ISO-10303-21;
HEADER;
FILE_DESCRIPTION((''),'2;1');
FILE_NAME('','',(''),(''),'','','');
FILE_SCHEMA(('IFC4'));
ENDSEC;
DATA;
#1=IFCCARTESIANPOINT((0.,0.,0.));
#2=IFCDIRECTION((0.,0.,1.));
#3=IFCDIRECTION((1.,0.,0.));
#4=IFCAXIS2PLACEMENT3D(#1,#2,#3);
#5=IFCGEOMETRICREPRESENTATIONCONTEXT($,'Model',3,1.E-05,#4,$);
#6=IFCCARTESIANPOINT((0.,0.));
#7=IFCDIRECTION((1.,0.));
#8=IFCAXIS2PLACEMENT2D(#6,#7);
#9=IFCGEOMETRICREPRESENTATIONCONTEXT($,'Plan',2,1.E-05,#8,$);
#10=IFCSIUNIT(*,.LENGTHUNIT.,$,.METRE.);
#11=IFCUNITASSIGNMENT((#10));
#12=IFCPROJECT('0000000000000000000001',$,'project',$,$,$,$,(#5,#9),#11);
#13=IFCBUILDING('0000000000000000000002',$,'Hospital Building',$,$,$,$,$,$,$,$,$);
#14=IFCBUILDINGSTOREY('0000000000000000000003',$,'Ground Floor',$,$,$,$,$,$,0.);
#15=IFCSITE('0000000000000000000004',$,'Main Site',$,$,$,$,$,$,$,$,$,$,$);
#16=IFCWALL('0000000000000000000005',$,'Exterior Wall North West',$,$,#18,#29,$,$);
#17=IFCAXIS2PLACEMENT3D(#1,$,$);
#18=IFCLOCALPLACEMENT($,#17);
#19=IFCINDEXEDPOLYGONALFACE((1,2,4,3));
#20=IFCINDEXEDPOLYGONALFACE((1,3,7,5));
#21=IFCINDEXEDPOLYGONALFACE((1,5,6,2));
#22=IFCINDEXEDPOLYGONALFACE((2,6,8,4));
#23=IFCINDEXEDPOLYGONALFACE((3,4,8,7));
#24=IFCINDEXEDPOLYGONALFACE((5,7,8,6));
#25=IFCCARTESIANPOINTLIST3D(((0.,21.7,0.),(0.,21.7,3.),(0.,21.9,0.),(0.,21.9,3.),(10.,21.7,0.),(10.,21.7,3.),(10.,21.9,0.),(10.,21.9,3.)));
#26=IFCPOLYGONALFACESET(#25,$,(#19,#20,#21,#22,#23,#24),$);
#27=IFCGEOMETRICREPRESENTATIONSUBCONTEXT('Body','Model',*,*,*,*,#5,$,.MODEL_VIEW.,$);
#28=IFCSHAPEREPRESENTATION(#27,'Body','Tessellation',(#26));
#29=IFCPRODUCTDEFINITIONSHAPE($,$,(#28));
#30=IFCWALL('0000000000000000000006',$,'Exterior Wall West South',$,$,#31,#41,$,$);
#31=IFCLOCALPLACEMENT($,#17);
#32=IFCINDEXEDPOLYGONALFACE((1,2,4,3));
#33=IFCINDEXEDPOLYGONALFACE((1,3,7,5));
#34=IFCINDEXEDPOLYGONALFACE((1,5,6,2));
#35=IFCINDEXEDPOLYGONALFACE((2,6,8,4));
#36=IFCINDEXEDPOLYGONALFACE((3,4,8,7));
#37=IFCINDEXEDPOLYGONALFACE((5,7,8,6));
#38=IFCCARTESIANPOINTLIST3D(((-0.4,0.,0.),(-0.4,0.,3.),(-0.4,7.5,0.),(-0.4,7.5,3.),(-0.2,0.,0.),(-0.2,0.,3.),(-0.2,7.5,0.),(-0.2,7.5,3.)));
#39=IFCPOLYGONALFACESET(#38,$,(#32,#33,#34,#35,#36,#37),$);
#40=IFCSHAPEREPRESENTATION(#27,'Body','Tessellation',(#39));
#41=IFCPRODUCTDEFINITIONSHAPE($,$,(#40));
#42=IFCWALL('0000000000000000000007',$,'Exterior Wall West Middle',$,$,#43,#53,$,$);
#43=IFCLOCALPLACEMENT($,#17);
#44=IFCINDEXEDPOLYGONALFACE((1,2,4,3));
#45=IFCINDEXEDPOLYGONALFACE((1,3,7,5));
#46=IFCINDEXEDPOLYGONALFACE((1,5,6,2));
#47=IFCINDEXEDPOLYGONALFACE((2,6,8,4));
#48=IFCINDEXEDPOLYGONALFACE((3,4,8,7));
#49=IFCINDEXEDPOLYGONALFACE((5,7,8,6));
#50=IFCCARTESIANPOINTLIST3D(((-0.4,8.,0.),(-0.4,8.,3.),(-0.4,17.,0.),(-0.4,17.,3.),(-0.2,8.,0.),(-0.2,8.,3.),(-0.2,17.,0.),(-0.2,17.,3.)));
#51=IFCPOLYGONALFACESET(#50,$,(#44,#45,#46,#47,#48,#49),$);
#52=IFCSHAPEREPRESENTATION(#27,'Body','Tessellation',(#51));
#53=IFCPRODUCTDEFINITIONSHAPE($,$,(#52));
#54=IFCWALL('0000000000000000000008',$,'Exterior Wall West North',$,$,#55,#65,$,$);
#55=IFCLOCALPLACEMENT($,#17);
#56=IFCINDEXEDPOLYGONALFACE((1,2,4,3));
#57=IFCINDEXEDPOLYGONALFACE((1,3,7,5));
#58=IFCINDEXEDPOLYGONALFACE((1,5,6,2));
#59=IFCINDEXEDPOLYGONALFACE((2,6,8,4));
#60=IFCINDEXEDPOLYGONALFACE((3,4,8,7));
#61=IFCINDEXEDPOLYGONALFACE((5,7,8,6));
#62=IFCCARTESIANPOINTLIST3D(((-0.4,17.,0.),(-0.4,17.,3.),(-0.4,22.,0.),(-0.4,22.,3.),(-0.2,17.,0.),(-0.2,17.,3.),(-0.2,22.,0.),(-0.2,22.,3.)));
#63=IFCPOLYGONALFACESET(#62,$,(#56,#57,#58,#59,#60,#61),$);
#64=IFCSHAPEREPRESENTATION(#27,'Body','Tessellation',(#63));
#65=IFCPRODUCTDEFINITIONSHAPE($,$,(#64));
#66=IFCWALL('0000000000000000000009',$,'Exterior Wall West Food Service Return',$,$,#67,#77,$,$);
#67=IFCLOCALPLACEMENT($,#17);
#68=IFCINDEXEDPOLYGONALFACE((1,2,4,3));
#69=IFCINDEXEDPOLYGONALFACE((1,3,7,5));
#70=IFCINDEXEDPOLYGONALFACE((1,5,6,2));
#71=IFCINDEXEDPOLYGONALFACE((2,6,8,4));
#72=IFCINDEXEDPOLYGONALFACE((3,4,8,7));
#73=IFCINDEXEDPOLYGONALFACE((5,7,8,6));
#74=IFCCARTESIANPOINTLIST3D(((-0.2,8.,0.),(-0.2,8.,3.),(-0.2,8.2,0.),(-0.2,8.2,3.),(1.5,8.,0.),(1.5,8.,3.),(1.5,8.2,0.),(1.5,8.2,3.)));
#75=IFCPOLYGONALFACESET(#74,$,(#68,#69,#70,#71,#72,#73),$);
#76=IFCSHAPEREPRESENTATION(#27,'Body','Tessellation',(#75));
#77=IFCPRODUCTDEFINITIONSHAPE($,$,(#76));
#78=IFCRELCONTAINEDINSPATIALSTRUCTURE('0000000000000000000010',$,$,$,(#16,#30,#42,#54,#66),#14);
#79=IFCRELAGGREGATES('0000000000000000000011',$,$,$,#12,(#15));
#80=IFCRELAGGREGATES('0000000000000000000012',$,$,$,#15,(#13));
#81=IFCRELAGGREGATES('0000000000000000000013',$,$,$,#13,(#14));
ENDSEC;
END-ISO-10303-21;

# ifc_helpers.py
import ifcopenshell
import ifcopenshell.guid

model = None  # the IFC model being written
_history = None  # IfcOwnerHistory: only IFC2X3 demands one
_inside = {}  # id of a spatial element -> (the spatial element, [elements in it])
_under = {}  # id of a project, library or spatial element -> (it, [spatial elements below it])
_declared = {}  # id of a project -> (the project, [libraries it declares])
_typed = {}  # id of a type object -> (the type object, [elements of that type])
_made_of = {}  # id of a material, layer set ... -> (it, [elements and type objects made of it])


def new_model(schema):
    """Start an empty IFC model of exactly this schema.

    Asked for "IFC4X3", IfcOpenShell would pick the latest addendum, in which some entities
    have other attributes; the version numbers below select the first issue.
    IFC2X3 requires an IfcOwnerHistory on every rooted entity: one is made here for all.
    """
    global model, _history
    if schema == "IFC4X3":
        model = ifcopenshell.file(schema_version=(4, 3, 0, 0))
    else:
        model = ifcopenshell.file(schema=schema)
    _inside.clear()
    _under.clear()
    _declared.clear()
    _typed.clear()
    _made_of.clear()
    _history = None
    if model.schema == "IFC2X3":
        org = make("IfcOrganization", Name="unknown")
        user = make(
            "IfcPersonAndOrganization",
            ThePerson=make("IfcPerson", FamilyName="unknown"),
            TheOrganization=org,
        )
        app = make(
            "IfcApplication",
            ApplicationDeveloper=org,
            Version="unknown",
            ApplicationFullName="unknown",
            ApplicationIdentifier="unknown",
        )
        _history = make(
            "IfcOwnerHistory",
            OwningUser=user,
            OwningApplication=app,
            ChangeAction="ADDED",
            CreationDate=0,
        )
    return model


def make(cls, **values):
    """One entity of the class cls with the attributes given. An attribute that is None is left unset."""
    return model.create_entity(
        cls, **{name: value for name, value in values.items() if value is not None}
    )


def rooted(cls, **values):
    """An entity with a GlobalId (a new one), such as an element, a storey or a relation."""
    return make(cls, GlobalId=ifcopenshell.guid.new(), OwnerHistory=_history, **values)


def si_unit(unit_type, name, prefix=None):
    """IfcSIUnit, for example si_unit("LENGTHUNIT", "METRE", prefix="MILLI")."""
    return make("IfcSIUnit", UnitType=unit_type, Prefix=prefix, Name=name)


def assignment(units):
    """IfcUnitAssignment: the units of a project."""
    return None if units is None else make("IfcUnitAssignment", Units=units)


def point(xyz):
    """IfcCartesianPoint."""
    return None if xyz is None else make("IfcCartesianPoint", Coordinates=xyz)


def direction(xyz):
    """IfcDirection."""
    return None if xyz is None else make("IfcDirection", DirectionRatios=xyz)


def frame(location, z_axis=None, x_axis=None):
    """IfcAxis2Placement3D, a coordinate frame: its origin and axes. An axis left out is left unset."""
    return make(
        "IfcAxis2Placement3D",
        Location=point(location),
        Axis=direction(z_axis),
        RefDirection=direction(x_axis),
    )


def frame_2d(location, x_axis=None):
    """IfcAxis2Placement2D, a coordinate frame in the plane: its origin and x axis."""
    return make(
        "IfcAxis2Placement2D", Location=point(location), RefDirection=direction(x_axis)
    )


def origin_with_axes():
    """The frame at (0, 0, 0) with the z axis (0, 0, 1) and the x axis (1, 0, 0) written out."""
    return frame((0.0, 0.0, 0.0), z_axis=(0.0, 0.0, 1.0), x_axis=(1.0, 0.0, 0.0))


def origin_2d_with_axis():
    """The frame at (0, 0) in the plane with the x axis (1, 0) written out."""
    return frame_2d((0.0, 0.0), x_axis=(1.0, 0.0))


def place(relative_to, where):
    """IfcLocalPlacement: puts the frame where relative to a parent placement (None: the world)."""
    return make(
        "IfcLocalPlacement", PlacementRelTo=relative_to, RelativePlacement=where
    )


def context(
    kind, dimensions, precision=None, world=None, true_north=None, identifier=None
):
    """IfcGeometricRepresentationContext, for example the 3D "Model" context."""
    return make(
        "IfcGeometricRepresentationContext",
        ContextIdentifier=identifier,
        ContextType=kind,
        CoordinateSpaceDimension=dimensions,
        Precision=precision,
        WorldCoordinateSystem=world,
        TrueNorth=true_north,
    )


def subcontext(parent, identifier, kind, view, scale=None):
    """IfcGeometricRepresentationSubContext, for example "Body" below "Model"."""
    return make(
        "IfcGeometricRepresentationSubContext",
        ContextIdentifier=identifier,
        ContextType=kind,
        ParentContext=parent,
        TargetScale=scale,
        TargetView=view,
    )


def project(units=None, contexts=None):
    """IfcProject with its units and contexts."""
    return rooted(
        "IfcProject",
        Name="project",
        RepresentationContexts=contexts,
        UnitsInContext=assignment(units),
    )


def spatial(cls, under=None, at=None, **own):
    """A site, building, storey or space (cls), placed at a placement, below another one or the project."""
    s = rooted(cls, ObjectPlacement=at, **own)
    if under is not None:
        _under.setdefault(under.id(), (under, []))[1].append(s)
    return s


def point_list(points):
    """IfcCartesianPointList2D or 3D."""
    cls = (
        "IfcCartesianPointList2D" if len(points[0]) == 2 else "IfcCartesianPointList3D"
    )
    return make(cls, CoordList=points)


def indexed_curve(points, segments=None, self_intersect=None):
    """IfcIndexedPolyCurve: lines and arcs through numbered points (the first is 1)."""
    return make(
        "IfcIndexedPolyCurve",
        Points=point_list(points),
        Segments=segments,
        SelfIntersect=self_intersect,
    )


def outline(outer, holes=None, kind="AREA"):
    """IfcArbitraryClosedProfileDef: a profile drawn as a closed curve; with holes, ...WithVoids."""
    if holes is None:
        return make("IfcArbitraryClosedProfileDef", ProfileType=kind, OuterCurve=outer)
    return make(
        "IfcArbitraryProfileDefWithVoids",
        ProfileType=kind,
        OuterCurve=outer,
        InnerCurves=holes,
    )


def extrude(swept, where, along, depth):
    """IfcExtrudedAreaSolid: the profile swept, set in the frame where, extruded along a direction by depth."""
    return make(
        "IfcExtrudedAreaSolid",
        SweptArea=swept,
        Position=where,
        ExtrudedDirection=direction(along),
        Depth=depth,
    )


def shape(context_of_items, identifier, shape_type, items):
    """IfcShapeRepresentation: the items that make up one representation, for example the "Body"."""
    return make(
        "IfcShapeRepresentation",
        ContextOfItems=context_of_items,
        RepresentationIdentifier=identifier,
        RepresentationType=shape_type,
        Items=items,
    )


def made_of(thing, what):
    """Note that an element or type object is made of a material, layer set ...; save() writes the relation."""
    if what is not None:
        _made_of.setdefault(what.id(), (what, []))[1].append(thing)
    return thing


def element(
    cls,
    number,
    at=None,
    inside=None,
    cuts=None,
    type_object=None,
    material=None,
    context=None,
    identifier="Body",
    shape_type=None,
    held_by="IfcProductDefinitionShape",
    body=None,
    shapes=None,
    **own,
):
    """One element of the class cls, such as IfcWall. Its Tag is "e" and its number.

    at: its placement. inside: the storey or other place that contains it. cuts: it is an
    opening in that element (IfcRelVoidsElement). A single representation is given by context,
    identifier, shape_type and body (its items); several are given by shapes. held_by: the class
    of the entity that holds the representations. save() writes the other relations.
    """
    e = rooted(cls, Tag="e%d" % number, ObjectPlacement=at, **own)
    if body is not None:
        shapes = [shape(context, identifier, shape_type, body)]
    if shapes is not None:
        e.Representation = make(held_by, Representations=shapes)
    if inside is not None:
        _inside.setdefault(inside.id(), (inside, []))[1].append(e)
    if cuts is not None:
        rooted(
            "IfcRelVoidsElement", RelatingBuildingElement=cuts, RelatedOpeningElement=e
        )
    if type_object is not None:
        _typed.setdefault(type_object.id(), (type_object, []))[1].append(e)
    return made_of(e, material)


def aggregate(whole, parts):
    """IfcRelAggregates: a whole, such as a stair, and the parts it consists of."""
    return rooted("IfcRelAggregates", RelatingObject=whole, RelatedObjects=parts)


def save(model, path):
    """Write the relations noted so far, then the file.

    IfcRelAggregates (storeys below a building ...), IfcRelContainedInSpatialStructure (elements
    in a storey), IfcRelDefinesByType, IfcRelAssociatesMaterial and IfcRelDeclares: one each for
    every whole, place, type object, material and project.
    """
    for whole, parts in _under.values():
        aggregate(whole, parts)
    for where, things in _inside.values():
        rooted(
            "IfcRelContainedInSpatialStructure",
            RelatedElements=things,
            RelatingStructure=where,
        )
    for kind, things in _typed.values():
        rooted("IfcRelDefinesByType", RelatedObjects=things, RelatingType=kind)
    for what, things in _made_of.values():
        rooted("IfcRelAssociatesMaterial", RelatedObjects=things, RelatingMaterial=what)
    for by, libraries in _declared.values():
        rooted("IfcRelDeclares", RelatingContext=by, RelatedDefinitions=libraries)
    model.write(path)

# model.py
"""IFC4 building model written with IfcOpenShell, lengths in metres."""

from ifc_helpers import new_model, si_unit, frame, origin_with_axes, origin_2d_with_axis, place, context, subcontext, project, spatial, indexed_curve, outline, extrude, element, save


model = new_model("IFC4")

# Units and contexts
model_context = context("Model", 3, precision=1e-05, world=origin_with_axes())
plan_context = context("Plan", 2, precision=1e-05, world=origin_2d_with_axis())
body_context = subcontext(model_context, "Body", "Model", "MODEL_VIEW")
ifc_project = project(units=[si_unit("LENGTHUNIT", "METRE")], contexts=[model_context, plan_context])

# Site, building, storey
site = spatial("IfcSite", under=ifc_project, Name="Main Site")
building = spatial("IfcBuilding", under=site, Name="Hospital Building")
storey = spatial("IfcBuildingStorey", under=building, Name="Ground Floor", Elevation=0.0)

# Walls
wall_1_placement = place(None, frame((0.0, 21.7, 0.0), z_axis=(0.0, 0.0, 1.0), x_axis=(1.0, 0.0, 0.0)))
element("IfcWall", 1, at=wall_1_placement, inside=storey, Name="Exterior Wall North West", context=body_context, shape_type="SweptSolid", body=[
    extrude(outline(indexed_curve([(0.0, 0.0), (0.0, 0.2), (10.0, 0.2), (10.0, 0.0), (0.0, 0.0)], self_intersect=False)), origin_with_axes(), (0.0, 0.0, 1.0), 3.0),
])
wall_2_placement = place(None, frame((-0.2, 0.0, 0.0), z_axis=(0.0, 0.0, 1.0), x_axis=(0.0, 1.0, 0.0)))
element("IfcWall", 2, at=wall_2_placement, inside=storey, Name="Exterior Wall West South", context=body_context, shape_type="SweptSolid", body=[
    extrude(outline(indexed_curve([(0.0, 0.0), (0.0, 0.2), (7.5, 0.2), (7.5, 0.0), (0.0, 0.0)], self_intersect=False)), origin_with_axes(), (0.0, 0.0, 1.0), 3.0),
])
wall_3_placement = place(None, frame((-0.2, 8.0, 0.0), z_axis=(0.0, 0.0, 1.0), x_axis=(0.0, 1.0, 0.0)))
element("IfcWall", 3, at=wall_3_placement, inside=storey, Name="Exterior Wall West Middle", context=body_context, shape_type="SweptSolid", body=[
    extrude(outline(indexed_curve([(0.0, 0.0), (0.0, 0.2), (9.0, 0.2), (9.0, 0.0), (0.0, 0.0)], self_intersect=False)), origin_with_axes(), (0.0, 0.0, 1.0), 3.0),
])
wall_4_placement = place(None, frame((-0.2, 17.0, 0.0), z_axis=(0.0, 0.0, 1.0), x_axis=(0.0, 1.0, 0.0)))
element("IfcWall", 4, at=wall_4_placement, inside=storey, Name="Exterior Wall West North", context=body_context, shape_type="SweptSolid", body=[
    extrude(outline(indexed_curve([(0.0, 0.0), (0.0, 0.2), (5.0, 0.2), (5.0, 0.0), (0.0, 0.0)], self_intersect=False)), origin_with_axes(), (0.0, 0.0, 1.0), 3.0),
])
wall_5_placement = place(None, frame((-0.2, 8.0, 0.0), z_axis=(0.0, 0.0, 1.0), x_axis=(1.0, 0.0, 0.0)))
element("IfcWall", 5, at=wall_5_placement, inside=storey, Name="Exterior Wall West Food Service Return", context=body_context, shape_type="SweptSolid", body=[
    extrude(outline(indexed_curve([(0.0, 0.0), (0.0, 0.2), (1.7, 0.2), (1.7, 0.0), (0.0, 0.0)], self_intersect=False)), origin_with_axes(), (0.0, 0.0, 1.0), 3.0),
])

save(model, "model.ifc")
